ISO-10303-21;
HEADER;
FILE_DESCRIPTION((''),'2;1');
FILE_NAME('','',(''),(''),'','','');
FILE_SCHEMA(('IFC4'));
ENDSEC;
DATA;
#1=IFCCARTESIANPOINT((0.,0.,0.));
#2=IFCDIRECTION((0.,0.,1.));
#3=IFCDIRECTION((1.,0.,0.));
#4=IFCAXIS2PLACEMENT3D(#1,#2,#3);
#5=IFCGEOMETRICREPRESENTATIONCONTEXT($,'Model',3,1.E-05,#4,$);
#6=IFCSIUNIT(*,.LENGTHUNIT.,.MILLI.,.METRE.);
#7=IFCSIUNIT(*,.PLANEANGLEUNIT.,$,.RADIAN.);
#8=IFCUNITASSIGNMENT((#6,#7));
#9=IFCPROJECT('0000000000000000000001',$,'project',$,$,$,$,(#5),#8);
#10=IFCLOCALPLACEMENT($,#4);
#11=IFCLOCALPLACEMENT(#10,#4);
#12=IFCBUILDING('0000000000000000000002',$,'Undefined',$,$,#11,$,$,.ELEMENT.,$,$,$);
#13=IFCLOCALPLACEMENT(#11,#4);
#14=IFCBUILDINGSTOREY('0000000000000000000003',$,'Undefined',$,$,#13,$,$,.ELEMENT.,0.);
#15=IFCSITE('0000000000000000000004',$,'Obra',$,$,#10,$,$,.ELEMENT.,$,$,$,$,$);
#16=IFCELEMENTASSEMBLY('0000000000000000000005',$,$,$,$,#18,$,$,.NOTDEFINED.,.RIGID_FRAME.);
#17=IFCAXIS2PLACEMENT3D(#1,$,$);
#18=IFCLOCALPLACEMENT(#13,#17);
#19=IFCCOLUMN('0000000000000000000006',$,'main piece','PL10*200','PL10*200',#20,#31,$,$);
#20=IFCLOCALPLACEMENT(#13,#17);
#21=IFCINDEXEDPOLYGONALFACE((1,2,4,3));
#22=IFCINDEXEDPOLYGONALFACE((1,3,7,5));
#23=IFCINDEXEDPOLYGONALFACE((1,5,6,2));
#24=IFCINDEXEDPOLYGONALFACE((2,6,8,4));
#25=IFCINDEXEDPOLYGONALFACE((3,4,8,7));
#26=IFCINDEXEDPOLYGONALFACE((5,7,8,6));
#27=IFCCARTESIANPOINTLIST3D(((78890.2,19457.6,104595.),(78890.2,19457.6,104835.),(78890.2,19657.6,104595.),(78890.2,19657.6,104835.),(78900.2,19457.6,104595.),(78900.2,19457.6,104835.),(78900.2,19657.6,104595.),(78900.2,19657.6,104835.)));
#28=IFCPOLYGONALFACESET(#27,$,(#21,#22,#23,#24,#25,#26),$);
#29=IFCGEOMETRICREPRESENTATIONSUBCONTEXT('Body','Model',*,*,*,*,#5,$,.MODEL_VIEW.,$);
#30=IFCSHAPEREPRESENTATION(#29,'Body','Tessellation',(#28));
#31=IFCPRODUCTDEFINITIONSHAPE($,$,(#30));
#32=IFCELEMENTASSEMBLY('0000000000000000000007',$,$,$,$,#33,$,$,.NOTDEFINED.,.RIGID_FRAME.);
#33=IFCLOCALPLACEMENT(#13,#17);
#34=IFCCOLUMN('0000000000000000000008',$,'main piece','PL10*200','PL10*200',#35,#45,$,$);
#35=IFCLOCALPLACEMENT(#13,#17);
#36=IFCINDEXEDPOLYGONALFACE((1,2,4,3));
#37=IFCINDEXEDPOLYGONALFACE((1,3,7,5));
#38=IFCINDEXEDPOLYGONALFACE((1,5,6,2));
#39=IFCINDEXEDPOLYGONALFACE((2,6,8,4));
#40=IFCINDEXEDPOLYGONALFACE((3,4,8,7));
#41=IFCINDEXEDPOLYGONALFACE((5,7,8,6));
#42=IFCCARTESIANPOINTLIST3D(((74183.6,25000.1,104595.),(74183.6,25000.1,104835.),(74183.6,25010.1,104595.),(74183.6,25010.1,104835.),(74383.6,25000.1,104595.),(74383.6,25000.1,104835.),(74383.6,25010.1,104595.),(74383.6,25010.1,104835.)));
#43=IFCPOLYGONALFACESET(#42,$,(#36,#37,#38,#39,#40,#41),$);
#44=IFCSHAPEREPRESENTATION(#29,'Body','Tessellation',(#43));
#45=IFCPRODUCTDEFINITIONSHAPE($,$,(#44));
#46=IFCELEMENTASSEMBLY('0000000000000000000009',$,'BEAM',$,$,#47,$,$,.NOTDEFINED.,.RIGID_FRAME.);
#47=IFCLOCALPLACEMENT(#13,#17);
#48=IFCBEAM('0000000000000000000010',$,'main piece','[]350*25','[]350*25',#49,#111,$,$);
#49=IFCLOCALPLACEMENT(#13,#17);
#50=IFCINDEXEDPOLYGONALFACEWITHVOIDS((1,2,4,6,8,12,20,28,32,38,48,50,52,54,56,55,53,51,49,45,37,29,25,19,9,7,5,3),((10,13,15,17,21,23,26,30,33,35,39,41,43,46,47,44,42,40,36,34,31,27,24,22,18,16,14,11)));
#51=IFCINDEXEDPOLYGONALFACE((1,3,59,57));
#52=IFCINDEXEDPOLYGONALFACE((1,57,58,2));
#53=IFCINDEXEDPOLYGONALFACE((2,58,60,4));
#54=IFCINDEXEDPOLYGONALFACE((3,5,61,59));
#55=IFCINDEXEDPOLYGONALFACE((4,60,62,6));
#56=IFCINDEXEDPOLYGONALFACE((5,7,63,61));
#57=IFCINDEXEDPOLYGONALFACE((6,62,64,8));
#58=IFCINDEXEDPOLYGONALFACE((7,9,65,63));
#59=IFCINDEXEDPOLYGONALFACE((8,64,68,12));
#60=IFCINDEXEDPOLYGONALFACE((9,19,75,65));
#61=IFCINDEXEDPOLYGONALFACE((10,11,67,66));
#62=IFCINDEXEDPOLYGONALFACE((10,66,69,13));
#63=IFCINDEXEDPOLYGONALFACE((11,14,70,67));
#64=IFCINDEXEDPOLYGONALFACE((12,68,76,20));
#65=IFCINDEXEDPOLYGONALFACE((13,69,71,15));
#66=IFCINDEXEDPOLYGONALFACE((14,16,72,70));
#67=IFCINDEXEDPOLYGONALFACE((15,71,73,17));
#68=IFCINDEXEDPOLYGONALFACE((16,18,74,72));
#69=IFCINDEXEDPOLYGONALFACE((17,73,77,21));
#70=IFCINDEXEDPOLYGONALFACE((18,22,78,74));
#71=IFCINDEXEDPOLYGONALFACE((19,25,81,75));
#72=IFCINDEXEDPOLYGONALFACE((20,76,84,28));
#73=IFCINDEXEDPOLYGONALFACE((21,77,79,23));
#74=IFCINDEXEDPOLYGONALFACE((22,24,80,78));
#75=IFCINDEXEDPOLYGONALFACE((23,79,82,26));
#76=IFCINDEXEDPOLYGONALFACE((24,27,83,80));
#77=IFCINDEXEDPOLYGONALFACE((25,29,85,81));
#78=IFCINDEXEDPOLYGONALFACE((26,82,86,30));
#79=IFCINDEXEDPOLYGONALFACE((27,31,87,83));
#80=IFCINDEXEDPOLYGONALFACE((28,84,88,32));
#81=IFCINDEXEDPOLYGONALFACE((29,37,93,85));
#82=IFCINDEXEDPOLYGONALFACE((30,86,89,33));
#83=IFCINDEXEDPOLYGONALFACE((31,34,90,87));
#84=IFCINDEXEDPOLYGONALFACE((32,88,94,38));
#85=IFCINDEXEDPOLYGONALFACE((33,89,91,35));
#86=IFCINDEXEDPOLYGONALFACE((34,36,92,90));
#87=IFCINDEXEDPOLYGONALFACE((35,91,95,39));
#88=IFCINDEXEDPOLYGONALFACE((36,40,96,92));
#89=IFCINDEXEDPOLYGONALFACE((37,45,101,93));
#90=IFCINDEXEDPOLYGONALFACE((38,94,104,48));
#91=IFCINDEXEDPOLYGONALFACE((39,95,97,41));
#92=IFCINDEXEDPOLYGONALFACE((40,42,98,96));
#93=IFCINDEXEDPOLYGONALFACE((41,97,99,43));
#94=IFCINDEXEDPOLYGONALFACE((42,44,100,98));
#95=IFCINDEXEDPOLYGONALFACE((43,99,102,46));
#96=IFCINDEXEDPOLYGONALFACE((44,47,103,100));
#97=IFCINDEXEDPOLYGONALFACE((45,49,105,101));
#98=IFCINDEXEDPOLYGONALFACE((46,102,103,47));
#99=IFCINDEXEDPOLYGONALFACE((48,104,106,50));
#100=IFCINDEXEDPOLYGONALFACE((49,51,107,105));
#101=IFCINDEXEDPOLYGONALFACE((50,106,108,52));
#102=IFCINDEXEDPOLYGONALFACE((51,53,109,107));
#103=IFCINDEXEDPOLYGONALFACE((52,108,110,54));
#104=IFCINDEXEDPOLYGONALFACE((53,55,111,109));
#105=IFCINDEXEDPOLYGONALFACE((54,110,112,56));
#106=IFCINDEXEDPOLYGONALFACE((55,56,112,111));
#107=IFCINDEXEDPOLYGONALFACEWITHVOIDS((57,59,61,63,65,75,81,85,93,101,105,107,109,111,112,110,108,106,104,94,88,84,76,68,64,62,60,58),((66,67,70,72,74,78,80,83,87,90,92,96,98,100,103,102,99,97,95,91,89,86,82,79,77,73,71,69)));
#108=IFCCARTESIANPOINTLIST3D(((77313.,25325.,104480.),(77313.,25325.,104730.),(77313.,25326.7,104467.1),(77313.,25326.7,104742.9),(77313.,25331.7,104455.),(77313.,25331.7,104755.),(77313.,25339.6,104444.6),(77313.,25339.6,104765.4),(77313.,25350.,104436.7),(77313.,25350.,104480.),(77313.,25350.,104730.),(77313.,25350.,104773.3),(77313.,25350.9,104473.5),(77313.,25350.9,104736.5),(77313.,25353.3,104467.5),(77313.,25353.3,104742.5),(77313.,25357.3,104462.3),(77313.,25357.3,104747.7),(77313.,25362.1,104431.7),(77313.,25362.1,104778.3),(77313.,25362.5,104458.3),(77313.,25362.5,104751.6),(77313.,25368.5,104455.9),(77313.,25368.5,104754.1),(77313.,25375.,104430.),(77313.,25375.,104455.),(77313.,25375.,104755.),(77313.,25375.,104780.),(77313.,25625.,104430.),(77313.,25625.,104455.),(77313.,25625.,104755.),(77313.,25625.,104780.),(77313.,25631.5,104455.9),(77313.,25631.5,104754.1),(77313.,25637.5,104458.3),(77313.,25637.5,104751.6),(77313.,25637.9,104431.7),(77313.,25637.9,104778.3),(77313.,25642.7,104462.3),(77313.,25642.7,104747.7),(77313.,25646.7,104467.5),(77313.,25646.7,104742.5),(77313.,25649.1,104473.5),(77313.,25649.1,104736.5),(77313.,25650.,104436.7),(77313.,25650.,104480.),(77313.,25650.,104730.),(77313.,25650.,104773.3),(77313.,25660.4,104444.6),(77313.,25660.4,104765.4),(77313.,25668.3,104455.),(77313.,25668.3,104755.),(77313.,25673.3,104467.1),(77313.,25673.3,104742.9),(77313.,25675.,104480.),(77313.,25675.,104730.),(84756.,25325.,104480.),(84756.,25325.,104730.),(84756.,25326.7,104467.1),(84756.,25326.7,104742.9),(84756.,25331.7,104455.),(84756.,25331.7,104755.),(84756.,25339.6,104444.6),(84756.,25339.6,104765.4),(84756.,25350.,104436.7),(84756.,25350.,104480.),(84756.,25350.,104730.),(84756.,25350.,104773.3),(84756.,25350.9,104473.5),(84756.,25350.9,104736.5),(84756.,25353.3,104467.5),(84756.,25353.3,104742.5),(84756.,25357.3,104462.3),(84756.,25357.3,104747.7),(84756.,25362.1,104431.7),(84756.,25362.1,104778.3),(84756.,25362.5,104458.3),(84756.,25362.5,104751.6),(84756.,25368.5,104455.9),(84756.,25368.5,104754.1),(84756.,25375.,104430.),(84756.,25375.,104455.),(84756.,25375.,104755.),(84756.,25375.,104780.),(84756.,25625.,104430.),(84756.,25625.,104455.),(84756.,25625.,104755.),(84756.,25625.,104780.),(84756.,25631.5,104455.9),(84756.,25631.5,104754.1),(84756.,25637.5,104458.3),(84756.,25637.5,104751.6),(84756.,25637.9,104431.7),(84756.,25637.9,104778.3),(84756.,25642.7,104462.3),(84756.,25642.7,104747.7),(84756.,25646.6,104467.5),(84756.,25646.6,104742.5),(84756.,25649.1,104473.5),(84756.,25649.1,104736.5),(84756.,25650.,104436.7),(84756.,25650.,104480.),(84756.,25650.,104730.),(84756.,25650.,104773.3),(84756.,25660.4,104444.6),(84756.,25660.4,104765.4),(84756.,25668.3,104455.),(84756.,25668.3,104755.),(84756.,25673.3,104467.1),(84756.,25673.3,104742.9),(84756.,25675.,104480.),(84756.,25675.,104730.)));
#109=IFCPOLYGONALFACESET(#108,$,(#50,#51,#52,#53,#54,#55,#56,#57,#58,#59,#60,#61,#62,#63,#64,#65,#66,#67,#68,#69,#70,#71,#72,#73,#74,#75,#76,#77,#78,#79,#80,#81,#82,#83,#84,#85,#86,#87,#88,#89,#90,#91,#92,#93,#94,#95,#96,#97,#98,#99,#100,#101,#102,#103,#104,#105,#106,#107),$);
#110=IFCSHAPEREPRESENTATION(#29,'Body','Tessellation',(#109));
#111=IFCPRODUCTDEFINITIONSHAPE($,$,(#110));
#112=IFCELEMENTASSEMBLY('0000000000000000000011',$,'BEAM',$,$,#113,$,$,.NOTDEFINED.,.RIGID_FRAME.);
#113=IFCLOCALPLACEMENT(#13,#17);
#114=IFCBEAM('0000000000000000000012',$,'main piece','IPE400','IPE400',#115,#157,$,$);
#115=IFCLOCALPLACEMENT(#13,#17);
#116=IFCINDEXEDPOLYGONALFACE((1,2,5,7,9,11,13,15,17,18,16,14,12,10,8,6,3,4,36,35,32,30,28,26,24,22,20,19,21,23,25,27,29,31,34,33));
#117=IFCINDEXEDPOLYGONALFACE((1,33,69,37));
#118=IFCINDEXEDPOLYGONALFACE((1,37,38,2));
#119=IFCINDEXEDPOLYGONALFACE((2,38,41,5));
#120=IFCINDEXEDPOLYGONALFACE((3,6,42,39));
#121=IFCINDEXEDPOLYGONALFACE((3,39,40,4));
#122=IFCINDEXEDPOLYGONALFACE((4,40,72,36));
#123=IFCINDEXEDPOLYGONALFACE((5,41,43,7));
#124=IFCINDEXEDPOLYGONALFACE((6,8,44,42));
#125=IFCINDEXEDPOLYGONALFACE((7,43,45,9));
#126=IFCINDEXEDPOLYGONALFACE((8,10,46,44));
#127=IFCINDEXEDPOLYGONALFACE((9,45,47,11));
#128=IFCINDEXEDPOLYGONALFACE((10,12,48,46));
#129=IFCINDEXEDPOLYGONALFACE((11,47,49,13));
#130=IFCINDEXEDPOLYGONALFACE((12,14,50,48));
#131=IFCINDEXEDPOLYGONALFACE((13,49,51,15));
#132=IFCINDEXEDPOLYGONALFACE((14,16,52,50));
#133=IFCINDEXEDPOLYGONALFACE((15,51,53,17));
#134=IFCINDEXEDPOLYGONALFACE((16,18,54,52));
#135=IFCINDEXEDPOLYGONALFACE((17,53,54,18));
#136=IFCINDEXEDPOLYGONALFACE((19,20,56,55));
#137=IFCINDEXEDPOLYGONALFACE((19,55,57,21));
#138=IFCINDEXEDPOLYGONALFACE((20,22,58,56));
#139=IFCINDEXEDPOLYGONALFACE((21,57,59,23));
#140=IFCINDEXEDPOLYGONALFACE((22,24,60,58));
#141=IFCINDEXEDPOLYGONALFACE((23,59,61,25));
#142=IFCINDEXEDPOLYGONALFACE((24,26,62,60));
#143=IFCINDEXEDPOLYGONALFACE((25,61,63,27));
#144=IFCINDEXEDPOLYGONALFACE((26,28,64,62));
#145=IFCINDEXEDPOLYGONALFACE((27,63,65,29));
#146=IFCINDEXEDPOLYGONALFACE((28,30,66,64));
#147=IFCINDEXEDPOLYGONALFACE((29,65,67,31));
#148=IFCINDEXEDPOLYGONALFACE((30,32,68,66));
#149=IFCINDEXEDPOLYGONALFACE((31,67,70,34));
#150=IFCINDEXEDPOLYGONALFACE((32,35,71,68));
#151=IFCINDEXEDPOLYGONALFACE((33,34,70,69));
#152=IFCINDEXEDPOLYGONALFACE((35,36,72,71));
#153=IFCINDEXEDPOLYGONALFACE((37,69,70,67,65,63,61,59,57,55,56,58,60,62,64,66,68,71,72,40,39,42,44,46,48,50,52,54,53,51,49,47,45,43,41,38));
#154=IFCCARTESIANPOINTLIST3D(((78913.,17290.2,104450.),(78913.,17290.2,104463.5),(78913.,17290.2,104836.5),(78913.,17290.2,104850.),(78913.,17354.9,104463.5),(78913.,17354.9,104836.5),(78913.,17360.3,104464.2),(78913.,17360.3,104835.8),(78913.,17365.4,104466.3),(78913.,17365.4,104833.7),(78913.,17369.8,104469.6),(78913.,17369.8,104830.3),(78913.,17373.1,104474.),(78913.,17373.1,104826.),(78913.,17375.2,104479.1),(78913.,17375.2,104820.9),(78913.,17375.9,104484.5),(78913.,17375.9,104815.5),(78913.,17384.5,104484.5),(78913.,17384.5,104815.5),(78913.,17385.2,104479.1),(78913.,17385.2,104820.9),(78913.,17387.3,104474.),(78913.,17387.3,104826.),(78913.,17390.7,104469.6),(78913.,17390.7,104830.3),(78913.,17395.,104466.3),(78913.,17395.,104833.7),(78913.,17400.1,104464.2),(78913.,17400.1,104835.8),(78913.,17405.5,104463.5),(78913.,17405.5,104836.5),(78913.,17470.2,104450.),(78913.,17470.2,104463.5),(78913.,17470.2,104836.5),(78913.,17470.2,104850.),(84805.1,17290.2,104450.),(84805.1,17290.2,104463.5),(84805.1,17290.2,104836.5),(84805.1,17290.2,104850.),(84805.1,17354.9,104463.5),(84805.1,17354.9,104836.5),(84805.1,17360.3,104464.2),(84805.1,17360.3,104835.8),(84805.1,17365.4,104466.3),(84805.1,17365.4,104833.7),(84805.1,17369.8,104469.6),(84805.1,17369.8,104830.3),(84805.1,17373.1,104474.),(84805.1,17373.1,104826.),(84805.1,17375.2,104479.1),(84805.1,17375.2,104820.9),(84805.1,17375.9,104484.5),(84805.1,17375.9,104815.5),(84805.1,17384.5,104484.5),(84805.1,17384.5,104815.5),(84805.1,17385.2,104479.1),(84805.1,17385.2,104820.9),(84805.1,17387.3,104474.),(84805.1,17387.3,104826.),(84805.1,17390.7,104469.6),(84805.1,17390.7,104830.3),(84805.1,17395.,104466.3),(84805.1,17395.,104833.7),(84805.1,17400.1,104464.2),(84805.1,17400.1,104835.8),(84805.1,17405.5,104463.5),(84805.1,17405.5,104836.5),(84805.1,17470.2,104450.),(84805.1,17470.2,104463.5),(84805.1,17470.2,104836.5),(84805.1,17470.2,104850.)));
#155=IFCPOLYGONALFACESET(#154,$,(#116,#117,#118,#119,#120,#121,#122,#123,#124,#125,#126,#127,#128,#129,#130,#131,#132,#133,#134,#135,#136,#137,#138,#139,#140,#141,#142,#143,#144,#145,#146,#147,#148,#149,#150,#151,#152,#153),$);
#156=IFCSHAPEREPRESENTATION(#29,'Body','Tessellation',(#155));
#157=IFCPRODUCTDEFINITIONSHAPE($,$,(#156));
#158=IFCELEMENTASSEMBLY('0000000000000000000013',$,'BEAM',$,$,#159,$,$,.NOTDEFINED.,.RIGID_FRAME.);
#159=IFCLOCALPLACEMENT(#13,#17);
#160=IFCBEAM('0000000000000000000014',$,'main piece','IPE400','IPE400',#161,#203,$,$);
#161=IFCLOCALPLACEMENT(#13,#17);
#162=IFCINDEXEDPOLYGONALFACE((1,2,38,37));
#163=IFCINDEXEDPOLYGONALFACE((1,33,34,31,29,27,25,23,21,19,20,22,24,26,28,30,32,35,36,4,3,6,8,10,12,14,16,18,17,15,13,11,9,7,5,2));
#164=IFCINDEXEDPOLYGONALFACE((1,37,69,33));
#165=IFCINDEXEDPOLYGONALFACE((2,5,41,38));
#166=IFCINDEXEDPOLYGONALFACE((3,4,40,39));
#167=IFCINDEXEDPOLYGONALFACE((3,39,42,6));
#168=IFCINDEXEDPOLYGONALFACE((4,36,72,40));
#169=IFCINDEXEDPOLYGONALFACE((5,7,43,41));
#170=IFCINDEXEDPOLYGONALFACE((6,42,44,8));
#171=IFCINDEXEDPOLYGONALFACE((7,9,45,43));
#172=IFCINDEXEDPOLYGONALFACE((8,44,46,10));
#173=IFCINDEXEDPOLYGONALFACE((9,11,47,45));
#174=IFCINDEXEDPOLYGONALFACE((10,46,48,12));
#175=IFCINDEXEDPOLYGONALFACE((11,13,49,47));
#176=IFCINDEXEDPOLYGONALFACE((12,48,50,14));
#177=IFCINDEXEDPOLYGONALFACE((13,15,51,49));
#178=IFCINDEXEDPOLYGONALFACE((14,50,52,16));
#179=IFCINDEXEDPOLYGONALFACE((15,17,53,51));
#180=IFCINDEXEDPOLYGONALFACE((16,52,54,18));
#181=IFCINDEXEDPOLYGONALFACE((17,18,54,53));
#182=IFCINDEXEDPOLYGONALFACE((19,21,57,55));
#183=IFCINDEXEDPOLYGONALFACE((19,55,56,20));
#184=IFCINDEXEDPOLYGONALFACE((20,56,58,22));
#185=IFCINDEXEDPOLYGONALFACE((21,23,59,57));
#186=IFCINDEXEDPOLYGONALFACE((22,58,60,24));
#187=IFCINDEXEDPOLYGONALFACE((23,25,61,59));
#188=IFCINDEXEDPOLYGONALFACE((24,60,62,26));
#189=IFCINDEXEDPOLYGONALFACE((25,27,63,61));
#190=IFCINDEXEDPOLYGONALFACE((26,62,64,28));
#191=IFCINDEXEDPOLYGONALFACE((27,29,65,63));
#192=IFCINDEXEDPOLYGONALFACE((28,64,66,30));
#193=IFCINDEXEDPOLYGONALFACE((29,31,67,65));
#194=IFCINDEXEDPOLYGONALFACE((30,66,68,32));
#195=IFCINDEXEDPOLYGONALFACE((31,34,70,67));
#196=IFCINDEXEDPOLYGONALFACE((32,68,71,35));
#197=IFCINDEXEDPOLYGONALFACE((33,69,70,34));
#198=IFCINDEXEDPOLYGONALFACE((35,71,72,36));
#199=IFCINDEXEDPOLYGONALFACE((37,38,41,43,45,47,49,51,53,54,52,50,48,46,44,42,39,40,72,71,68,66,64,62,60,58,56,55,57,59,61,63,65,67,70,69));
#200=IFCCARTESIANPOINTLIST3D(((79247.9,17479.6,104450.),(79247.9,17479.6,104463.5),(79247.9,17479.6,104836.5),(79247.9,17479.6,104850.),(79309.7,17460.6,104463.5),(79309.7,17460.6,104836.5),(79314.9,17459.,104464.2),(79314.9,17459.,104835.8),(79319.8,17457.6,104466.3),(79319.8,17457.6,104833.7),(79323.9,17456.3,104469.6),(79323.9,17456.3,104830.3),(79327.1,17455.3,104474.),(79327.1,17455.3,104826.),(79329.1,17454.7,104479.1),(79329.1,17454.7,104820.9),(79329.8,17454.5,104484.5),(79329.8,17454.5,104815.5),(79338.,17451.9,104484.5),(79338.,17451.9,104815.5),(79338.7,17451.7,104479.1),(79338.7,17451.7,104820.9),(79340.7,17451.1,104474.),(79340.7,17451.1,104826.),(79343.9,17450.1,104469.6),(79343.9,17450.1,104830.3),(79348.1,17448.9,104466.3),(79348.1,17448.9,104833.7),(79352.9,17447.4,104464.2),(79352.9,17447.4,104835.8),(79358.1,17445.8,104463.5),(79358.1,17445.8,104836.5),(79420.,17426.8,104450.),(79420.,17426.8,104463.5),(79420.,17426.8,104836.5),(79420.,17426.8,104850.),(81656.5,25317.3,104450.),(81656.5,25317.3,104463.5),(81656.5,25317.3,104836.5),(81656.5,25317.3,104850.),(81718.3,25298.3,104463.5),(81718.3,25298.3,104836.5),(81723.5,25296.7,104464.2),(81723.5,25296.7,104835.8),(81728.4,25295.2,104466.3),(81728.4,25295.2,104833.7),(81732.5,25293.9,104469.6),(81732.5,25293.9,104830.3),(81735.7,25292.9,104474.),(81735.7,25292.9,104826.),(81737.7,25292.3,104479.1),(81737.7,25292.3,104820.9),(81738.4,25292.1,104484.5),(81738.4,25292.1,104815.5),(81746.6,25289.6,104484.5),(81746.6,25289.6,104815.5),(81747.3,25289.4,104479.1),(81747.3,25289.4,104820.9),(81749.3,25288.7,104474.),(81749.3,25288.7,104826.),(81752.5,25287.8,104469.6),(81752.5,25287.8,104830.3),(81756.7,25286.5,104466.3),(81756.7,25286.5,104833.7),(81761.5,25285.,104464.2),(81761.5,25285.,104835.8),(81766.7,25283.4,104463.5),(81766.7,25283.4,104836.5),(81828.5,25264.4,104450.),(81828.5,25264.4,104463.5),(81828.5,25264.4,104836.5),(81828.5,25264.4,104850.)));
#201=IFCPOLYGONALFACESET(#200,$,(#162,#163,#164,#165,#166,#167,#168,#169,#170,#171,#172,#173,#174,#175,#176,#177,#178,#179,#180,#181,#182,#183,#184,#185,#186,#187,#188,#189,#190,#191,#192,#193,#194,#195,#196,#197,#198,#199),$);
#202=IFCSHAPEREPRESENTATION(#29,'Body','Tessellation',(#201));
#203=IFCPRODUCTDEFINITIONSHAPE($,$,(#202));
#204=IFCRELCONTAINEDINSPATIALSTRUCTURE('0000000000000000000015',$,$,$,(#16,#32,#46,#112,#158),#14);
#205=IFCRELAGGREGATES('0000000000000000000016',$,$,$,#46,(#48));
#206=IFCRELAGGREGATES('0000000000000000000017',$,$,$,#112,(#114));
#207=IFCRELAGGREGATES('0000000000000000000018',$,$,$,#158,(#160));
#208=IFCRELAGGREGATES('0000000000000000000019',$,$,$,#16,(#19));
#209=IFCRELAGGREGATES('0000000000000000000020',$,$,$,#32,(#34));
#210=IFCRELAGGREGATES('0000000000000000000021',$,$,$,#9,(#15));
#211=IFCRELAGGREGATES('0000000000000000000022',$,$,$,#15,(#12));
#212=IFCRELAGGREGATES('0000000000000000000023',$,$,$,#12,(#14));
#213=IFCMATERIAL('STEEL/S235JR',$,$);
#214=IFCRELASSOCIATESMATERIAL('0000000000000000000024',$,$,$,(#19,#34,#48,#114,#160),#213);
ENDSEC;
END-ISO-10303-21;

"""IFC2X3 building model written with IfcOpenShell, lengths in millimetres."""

from ifc_helpers import new_model, si_unit, frame, origin_with_axes, origin_2d_with_axis, place, context, subcontext, project, spatial, rectangle, hollow_rectangle, i_section, extrude, material, element, aggregate, save


model = new_model("IFC2X3")

# Units and contexts
model_context = context("Model", 3, precision=1e-05, world=origin_with_axes())
body_context = subcontext(model_context, "Body", "Model", "MODEL_VIEW")
ifc_project = project(units=[si_unit("LENGTHUNIT", "METRE", prefix="MILLI"), si_unit("PLANEANGLEUNIT", "RADIAN")], contexts=[model_context])

# Site, building, storey
site_placement = place(None, origin_with_axes())
site = spatial("IfcSite", under=ifc_project, at=site_placement, Name="Obra", CompositionType="ELEMENT")
building_placement = place(site_placement, origin_with_axes())
building = spatial("IfcBuilding", under=site, at=building_placement, Name="Undefined", CompositionType="ELEMENT")
storey_placement = place(building_placement, origin_with_axes())
storey = spatial("IfcBuildingStorey", under=building, at=storey_placement, Name="Undefined", CompositionType="ELEMENT", Elevation=0.0)

# Element assemblies, columns
assembly_1_placement = place(storey_placement, origin_with_axes())
assembly_1 = element("IfcElementAssembly", 1, at=assembly_1_placement, inside=storey, AssemblyPlace="NOTDEFINED", PredefinedType="RIGID_FRAME")
ifc_material = material(Name="STEEL/S235JR")
column_1_placement = place(assembly_1_placement, frame((78895.2, 19557.6, 104595.0), z_axis=(0.0, 0.0, 1.0), x_axis=(0.0, -1.0, 0.0)))
column_1 = element("IfcColumn", 2, at=column_1_placement, material=ifc_material, Name="main piece", Description="PL10*200", ObjectType="PL10*200", context=body_context, shape_type="SweptSolid", body=[
    extrude(rectangle(XDim=10.0, YDim=200.0, at=origin_2d_with_axis()), frame((0.0, 0.0, 240.0), z_axis=(0.0, 0.0, -1.0), x_axis=(0.0, 1.0, 0.0)), (0.0, 0.0, 1.0), 240.0),
])
assembly_2_placement = place(storey_placement, origin_with_axes())
assembly_2 = element("IfcElementAssembly", 3, at=assembly_2_placement, inside=storey, AssemblyPlace="NOTDEFINED", PredefinedType="RIGID_FRAME")
column_2_placement = place(assembly_2_placement, frame((74283.6, 25005.1, 104595.0), z_axis=(0.0, 0.0, 1.0), x_axis=(-1.0, -0.000002, 0.0)))
column_2 = element("IfcColumn", 4, at=column_2_placement, material=ifc_material, Name="main piece", Description="PL10*200", ObjectType="PL10*200", context=body_context, shape_type="SweptSolid", body=[
    extrude(rectangle(XDim=10.0, YDim=200.0, at=origin_2d_with_axis()), frame((0.0, 0.0, 240.0), z_axis=(0.0, 0.0, -1.0), x_axis=(0.0, 1.0, 0.0)), (0.0, 0.0, 1.0), 240.0),
])

# Element assemblies, beams
assembly_3_placement = place(storey_placement, origin_with_axes())
assembly_3 = element("IfcElementAssembly", 5, at=assembly_3_placement, inside=storey, Name="BEAM", AssemblyPlace="NOTDEFINED", PredefinedType="RIGID_FRAME")
beam_1_placement = place(assembly_3_placement, frame((84756.0, 25500.0, 104605.0), z_axis=(0.0, 0.0, 1.0), x_axis=(-1.0, 0.0, 0.0)))
beam_1 = element("IfcBeam", 6, at=beam_1_placement, material=ifc_material, Name="main piece", Description="[]350*25", ObjectType="[]350*25", context=body_context, shape_type="SweptSolid", body=[
    extrude(hollow_rectangle(XDim=350.0, YDim=350.0, WallThickness=25.0, InnerFilletRadius=25.0, OuterFilletRadius=50.0, at=origin_2d_with_axis()), frame((7443.0, 0.0, 0.0), z_axis=(-1.0, 0.0, 0.0), x_axis=(0.0, -1.0, 0.0)), (0.0, 0.0, 1.0), 7443.0),
])
aggregate(assembly_3, [beam_1])
assembly_4_placement = place(storey_placement, origin_with_axes())
assembly_4 = element("IfcElementAssembly", 7, at=assembly_4_placement, inside=storey, Name="BEAM", AssemblyPlace="NOTDEFINED", PredefinedType="RIGID_FRAME")
beam_2_placement = place(assembly_4_placement, frame((78913.0, 17380.2, 104650.0), z_axis=(0.0, 0.0, 1.0), x_axis=(1.0, 0.0, 0.0)))
beam_2 = element("IfcBeam", 8, at=beam_2_placement, material=ifc_material, Name="main piece", Description="IPE400", ObjectType="IPE400", context=body_context, shape_type="SweptSolid", body=[
    extrude(i_section(OverallWidth=180.0, OverallDepth=400.0, WebThickness=8.6, FlangeThickness=13.5, FilletRadius=21.0, at=origin_2d_with_axis()), frame((5892.1, 0.0, 0.0), z_axis=(-1.0, 0.0, 0.0), x_axis=(0.0, -1.0, 0.0)), (0.0, 0.0, 1.0), 5892.1),
])
aggregate(assembly_4, [beam_2])

# Element assembly, beam
assembly_5_placement = place(storey_placement, origin_with_axes())
assembly_5 = element("IfcElementAssembly", 9, at=assembly_5_placement, inside=storey, Name="BEAM", AssemblyPlace="NOTDEFINED", PredefinedType="RIGID_FRAME")
beam_3_placement = place(assembly_5_placement, frame((79333.9, 17453.2, 104650.0), z_axis=(0.0, 0.0, 1.0), x_axis=(0.293752, 0.955882, 0.0)))
beam_3 = element("IfcBeam", 10, at=beam_3_placement, material=ifc_material, Name="main piece", Description="IPE400", ObjectType="IPE400", context=body_context, shape_type="SweptSolid", body=[
    extrude(i_section(OverallWidth=180.0, OverallDepth=400.0, WebThickness=8.6, FlangeThickness=13.5, FilletRadius=21.0, at=origin_2d_with_axis()), frame((8199.4, 0.0, 0.0), z_axis=(-1.0, 0.0, 0.0), x_axis=(0.0, -1.0, 0.0)), (0.0, 0.0, 1.0), 8199.4),
])
aggregate(assembly_5, [beam_3])

aggregate(assembly_1, [column_1])

aggregate(assembly_2, [column_2])

save(model, "model.ifc")
